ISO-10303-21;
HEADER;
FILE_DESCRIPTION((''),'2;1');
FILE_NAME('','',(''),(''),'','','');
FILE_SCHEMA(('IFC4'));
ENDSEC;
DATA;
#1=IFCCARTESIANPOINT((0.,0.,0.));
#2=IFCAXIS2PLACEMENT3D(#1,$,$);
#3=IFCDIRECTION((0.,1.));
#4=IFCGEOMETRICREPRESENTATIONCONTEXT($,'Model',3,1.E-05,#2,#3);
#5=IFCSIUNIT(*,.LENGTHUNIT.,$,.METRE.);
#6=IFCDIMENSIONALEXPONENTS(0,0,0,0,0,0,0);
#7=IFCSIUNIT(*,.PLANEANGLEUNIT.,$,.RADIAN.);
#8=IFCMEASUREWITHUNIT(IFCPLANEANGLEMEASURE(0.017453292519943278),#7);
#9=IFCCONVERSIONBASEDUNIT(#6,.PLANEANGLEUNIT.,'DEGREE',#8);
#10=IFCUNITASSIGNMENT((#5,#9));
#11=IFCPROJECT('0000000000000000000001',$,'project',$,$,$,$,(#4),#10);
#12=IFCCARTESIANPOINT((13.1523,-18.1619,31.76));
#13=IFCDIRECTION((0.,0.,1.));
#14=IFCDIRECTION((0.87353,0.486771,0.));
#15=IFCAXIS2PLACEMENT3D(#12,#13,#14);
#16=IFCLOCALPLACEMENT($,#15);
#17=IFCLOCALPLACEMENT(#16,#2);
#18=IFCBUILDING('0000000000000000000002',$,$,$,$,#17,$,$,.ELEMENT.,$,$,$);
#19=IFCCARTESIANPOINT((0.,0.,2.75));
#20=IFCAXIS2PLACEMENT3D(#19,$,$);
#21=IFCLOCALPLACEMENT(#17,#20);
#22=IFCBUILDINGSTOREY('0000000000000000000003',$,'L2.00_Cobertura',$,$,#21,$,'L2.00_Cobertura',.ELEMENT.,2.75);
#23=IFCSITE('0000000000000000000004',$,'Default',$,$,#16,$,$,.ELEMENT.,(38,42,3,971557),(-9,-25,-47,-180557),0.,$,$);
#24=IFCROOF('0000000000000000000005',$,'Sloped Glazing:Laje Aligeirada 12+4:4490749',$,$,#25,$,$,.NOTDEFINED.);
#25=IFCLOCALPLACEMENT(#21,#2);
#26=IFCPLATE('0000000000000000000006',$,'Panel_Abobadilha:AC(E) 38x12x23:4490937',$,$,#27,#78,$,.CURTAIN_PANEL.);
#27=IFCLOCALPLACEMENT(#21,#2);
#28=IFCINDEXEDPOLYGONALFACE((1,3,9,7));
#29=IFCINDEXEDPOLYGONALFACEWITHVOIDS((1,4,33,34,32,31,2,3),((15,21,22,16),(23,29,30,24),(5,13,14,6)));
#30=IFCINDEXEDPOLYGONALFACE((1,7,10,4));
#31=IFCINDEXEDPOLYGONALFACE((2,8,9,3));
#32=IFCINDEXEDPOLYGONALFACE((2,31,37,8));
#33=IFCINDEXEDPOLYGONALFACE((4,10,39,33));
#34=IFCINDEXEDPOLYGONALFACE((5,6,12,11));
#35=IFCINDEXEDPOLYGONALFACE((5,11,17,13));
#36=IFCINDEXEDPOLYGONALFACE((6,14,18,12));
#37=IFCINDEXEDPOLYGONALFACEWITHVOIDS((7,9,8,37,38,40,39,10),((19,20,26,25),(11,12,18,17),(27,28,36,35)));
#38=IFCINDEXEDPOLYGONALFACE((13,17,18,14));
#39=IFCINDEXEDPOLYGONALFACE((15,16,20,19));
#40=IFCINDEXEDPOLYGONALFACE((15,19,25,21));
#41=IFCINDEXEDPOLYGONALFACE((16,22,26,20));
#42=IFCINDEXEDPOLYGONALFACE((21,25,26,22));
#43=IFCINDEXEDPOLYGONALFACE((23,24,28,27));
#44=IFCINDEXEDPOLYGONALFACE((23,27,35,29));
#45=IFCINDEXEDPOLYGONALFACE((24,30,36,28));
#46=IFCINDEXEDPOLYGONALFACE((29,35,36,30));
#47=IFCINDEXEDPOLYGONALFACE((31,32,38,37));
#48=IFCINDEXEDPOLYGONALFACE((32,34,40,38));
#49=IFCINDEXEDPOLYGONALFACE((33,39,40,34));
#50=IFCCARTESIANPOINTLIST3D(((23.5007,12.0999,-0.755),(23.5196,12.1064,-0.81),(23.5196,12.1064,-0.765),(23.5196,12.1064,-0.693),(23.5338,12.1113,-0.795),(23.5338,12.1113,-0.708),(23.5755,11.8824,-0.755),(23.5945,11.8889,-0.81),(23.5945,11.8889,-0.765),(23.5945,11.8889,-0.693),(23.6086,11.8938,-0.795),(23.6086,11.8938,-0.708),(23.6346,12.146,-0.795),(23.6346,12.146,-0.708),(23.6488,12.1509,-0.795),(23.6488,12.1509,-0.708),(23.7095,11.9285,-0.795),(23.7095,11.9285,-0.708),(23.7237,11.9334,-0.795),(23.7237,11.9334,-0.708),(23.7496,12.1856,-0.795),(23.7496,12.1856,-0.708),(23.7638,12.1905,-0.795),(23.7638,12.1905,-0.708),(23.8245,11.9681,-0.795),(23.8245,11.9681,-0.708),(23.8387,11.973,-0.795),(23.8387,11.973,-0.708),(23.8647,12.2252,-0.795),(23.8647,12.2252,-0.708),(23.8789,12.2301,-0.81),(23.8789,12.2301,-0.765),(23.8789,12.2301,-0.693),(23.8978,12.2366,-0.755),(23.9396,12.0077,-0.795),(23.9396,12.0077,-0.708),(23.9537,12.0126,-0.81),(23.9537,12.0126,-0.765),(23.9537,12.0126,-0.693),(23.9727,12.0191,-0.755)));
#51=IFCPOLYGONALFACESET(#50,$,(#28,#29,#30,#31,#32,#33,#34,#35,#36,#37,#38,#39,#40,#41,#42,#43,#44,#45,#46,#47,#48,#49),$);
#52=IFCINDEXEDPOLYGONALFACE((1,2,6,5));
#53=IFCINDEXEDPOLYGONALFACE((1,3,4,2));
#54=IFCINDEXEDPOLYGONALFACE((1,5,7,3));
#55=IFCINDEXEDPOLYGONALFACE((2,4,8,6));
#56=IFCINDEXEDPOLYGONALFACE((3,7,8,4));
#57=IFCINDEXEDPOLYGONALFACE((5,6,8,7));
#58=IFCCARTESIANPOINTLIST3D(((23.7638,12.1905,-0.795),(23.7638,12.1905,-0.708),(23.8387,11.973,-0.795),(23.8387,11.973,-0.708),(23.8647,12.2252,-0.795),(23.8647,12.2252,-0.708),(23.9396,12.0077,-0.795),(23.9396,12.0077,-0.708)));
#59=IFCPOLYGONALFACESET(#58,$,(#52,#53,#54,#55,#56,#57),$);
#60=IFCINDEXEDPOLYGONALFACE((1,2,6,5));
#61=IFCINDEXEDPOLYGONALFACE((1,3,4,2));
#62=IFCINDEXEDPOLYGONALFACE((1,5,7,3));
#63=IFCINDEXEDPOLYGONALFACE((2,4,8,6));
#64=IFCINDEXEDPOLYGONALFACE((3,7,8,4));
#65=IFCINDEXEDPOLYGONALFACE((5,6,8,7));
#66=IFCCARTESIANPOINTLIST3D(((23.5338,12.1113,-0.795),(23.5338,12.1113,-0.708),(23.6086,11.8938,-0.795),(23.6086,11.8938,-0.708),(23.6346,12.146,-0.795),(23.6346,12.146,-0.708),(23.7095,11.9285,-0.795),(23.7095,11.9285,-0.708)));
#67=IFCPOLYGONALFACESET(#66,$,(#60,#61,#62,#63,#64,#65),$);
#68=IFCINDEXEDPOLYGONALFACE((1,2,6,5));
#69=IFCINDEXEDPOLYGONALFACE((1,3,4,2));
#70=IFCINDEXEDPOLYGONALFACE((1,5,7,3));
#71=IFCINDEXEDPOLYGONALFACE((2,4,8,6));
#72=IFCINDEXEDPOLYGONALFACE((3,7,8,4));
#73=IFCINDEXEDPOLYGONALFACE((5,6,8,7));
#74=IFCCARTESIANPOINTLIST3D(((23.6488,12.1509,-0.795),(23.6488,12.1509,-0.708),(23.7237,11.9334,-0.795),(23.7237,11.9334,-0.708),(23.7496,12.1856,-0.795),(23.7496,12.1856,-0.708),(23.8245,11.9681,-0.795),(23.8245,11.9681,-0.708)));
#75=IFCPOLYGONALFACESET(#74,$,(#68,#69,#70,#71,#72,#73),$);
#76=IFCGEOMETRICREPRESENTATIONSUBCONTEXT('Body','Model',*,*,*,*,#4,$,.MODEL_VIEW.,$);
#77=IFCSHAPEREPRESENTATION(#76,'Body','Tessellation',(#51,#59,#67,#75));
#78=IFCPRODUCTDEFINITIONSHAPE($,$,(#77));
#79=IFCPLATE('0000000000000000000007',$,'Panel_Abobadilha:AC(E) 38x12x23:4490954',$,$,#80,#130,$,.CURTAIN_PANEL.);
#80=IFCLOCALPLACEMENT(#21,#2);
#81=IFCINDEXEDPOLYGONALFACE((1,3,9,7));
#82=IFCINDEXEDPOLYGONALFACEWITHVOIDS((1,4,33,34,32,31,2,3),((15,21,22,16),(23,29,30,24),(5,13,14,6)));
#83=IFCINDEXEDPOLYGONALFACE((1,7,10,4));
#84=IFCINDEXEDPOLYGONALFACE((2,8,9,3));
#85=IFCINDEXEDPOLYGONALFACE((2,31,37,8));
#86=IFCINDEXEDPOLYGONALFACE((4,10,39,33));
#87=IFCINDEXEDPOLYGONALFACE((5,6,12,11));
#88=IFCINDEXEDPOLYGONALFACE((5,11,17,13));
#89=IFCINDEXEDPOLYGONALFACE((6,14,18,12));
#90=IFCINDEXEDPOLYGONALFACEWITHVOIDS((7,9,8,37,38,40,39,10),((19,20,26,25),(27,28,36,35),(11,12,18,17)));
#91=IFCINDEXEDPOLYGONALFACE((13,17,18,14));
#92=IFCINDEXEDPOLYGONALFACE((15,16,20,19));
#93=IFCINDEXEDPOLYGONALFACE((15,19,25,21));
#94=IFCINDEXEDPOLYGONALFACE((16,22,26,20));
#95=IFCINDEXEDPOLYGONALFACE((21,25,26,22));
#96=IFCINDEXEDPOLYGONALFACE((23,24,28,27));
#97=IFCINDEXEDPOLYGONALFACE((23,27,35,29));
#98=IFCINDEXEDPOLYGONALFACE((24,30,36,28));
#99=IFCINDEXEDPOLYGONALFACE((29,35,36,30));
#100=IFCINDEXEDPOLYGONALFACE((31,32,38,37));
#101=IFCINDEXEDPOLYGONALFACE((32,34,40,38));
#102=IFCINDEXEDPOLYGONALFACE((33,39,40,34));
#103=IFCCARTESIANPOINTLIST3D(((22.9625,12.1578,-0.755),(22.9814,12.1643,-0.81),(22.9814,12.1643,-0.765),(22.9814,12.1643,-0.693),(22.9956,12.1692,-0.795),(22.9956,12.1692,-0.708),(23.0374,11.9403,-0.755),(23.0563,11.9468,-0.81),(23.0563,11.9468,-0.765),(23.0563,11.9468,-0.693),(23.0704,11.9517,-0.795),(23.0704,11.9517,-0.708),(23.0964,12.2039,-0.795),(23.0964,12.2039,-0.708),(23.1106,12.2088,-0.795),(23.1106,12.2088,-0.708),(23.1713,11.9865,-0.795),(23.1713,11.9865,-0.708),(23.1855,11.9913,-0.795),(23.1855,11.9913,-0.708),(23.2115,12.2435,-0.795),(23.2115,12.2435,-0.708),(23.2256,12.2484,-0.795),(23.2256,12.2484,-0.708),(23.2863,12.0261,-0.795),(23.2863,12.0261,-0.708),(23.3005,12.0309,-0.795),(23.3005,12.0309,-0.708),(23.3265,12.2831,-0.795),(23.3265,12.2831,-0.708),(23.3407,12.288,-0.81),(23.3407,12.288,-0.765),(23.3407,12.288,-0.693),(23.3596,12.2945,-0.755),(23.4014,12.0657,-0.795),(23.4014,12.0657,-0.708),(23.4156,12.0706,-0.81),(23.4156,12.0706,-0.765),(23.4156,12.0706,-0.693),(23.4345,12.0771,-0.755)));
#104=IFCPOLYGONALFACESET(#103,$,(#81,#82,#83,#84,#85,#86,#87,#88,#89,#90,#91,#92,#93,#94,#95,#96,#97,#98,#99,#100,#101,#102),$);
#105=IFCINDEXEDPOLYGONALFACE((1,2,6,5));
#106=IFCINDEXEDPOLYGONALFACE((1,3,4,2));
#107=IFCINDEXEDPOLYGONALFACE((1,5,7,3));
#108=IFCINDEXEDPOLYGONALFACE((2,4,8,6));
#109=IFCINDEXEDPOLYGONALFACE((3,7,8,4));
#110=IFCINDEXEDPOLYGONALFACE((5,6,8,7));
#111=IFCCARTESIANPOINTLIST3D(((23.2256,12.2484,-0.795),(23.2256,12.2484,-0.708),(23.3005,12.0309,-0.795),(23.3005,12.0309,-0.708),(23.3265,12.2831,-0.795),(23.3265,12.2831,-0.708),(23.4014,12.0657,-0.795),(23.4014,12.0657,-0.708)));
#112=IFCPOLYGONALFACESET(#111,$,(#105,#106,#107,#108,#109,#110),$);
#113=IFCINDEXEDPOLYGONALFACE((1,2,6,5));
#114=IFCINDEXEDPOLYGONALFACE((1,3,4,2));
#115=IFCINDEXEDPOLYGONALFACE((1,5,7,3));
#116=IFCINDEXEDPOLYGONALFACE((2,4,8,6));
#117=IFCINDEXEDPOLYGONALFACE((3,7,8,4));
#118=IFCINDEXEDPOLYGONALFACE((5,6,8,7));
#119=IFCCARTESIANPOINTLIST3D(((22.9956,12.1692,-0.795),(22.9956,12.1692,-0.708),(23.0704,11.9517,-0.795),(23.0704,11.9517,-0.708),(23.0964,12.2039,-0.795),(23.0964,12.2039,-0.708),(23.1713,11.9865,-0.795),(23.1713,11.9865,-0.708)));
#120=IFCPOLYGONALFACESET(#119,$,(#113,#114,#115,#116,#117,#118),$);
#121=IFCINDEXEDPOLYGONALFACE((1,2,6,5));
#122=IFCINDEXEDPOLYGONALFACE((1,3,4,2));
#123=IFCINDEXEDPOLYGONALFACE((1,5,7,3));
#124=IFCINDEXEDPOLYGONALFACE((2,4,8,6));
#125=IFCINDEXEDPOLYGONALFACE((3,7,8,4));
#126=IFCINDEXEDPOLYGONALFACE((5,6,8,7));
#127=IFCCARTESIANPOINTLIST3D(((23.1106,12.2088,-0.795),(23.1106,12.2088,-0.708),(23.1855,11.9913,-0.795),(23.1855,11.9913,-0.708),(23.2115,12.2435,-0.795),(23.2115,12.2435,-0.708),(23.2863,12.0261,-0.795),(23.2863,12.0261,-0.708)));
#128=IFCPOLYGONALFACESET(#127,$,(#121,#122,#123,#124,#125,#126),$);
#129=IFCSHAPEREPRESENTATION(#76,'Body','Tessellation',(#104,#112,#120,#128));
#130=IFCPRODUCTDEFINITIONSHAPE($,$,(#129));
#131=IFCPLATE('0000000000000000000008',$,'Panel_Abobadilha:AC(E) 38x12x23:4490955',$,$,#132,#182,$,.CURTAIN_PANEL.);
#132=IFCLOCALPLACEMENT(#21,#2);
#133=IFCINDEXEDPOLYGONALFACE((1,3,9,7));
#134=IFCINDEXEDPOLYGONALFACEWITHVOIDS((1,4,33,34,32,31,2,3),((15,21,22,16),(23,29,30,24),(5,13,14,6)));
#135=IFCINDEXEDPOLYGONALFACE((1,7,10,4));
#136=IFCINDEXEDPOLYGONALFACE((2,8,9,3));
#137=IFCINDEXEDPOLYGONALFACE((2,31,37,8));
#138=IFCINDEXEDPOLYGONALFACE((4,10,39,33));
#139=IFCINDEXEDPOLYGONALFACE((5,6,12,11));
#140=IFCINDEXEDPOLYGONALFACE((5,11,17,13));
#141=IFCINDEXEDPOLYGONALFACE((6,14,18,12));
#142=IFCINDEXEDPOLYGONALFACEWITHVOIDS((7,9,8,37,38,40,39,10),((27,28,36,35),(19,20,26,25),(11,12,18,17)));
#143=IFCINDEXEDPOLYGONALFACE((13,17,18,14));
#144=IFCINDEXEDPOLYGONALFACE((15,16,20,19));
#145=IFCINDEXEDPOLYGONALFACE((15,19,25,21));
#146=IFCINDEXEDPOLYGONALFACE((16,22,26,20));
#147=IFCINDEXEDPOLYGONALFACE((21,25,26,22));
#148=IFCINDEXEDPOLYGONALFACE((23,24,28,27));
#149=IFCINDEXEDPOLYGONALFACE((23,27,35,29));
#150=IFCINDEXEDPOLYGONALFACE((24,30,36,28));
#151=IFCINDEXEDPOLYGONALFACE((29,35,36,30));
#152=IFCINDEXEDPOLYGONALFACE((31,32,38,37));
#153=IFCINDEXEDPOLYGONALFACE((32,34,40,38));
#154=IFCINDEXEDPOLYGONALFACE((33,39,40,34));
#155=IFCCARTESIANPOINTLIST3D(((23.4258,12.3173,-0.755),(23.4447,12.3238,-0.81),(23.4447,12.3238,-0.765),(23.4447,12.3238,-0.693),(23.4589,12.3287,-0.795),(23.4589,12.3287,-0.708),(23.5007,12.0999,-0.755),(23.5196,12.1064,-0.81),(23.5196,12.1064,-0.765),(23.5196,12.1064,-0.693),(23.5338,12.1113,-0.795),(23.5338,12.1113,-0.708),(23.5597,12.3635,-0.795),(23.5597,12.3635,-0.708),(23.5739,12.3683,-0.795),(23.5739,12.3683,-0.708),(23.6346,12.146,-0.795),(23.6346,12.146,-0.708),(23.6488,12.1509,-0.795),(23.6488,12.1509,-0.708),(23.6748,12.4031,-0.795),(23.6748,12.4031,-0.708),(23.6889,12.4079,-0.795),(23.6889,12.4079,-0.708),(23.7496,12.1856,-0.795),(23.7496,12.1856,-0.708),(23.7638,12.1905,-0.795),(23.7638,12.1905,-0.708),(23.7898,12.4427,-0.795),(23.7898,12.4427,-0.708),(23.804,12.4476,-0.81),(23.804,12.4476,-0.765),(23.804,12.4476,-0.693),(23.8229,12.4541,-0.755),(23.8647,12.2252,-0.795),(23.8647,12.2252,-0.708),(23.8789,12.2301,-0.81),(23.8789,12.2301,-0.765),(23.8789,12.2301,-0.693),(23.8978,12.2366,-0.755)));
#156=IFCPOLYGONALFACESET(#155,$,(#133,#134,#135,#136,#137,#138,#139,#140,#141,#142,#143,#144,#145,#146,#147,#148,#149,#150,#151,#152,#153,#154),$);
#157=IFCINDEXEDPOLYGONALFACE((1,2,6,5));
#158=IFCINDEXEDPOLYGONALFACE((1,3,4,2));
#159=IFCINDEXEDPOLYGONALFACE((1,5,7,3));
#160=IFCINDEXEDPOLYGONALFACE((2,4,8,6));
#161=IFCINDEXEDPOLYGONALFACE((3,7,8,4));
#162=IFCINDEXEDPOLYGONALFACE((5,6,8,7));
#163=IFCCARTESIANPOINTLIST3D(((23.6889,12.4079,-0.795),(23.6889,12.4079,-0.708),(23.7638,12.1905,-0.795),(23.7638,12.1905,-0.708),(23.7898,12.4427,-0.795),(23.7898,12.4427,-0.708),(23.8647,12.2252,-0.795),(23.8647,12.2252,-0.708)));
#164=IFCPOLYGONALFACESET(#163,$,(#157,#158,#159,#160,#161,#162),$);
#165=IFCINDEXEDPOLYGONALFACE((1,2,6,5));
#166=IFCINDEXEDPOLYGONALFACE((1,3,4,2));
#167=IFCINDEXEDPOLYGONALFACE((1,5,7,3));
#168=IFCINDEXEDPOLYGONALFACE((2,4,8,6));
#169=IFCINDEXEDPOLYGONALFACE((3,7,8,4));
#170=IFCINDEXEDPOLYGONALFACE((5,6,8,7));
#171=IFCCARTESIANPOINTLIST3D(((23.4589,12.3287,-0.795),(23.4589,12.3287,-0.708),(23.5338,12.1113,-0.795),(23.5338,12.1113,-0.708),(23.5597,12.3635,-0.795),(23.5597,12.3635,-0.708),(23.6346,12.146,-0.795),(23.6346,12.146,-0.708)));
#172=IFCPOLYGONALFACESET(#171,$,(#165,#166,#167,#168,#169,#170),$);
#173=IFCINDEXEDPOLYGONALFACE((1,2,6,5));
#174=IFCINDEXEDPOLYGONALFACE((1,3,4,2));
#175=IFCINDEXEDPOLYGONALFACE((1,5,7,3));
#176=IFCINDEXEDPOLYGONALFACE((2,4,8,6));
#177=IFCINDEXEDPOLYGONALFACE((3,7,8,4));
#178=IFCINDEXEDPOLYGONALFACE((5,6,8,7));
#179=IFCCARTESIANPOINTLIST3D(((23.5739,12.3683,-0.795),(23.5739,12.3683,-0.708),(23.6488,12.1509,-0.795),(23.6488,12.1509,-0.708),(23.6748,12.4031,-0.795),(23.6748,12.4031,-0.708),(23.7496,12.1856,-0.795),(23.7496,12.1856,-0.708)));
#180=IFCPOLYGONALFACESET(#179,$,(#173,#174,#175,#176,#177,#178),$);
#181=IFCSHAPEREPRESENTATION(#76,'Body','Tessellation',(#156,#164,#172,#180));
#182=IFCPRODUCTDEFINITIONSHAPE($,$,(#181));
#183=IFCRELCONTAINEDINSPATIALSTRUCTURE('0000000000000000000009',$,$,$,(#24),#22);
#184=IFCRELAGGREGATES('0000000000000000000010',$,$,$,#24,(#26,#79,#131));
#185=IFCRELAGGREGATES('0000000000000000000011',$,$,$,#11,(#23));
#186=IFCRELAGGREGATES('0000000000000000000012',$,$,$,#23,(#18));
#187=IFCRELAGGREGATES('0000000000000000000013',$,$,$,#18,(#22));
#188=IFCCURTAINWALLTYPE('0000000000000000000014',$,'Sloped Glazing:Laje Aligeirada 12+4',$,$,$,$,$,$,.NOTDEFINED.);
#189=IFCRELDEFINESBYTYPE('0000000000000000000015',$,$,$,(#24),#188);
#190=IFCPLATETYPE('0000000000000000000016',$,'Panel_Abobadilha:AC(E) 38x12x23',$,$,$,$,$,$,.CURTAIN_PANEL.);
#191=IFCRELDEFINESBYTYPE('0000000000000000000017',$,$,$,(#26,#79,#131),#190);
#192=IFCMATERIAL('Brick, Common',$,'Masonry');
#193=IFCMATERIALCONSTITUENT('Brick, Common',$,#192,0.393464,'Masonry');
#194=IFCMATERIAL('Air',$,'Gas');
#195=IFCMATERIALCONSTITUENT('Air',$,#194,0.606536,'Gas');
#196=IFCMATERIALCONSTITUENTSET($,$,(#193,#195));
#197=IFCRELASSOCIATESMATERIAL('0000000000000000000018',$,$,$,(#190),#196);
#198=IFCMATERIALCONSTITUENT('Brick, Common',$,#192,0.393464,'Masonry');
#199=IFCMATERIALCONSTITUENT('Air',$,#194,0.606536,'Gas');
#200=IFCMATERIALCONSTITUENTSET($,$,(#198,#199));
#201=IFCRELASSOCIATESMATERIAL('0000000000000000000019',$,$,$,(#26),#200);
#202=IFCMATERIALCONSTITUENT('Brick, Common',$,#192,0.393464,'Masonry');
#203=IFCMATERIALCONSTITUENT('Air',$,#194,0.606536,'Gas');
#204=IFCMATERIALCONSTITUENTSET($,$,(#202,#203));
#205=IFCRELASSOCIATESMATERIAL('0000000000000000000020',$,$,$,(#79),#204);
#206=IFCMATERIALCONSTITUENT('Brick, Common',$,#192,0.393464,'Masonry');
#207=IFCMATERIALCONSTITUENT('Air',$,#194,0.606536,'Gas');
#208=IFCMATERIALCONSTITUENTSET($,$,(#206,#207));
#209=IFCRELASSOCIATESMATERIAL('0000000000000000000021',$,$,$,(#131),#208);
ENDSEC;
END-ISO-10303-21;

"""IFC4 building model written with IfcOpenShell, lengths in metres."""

from ifc_helpers import new_model, entity, si_unit, converted_unit, direction, frame, origin, place, context, subcontext, project, spatial, indexed_curve, outline, extrude, source, transform, mapped, material, constituent, constituent_set, type_object, type_shapes, element, aggregate, save


model = new_model("IFC4")

# Units and contexts
model_context = context("Model", 3, precision=1e-05, world=origin(), true_north=direction((0.0, 1.0)))
body_context = subcontext(model_context, "Body", "Model", "MODEL_VIEW")
ifc_project = project(units=[si_unit("LENGTHUNIT", "METRE"), converted_unit("PLANEANGLEUNIT", "DEGREE", entity("IfcPlaneAngleMeasure", 0.017453292519943278), si_unit("PLANEANGLEUNIT", "RADIAN"), dimensions=[0, 0, 0, 0, 0, 0, 0])], contexts=[model_context])

# Site, building, storey
site_placement = place(None, frame((13.1523, -18.1619, 31.76), z_axis=(0.0, 0.0, 1.0), x_axis=(0.87353, 0.486771, 0.0)))
site = spatial("IfcSite", under=ifc_project, at=site_placement, Name="Default", CompositionType="ELEMENT", RefLatitude=(38, 42, 3, 971557), RefLongitude=(-9, -25, -47, -180557), RefElevation=0.0)
building_placement = place(site_placement, origin())
building = spatial("IfcBuilding", under=site, at=building_placement, CompositionType="ELEMENT")
storey_placement = place(building_placement, frame((0.0, 0.0, 2.75)))
storey = spatial("IfcBuildingStorey", under=building, at=storey_placement, Name="L2.00_Cobertura", LongName="L2.00_Cobertura", CompositionType="ELEMENT", Elevation=2.75)

# Roof, plates
curtain_wall_type = type_object("IfcCurtainWallType", Name="Sloped Glazing:Laje Aligeirada 12+4", PredefinedType="NOTDEFINED")
roof_placement = place(storey_placement, frame((0.0, 0.0, -2.75)))
roof = element("IfcRoof", 1, at=roof_placement, inside=storey, type_object=curtain_wall_type, Name="Sloped Glazing:Laje Aligeirada 12+4:4490749", PredefinedType="NOTDEFINED")
ifc_material_1 = material(Name="Brick, Common", Category="Masonry")
ifc_material_2 = material(Name="Air", Category="Gas")
ifc_constituent_1 = constituent(ifc_material_1, Name="Brick, Common", Category="Masonry", fraction=0.393464)
ifc_constituent_2 = constituent(ifc_material_2, Name="Air", Category="Gas", fraction=0.606536)
ifc_constituent_set_1 = constituent_set(constituents=[ifc_constituent_1, ifc_constituent_2])
plate_type_1 = type_object("IfcPlateType", Name="Panel_Abobadilha:AC(E) 38x12x23", PredefinedType="CURTAIN_PANEL", material=ifc_constituent_set_1)
shared_shape_1 = source(origin(), body_context, "Body", "SweptSolid", [
    extrude(outline(indexed_curve([(-0.19, -0.0543), (0.19, -0.0543), (0.19, -0.0093), (0.21, 0.0007), (0.19, 0.0628), (-0.19, 0.0628), (-0.21, 0.0007), (-0.19, -0.0093), (-0.19, -0.0543)], self_intersect=False), holes=[indexed_curve([(-0.0683, 0.0477), (-0.0683, -0.0393), (-0.175, -0.0393), (-0.175, 0.0477), (-0.0683, 0.0477)], self_intersect=False), indexed_curve([(0.0533, 0.0477), (0.0533, -0.0393), (-0.0533, -0.0393), (-0.0533, 0.0477), (0.0533, 0.0477)], self_intersect=False), indexed_curve([(0.175, 0.0477), (0.175, -0.0393), (0.0683, -0.0393), (0.0683, 0.0477), (0.175, 0.0477)], self_intersect=False)]), frame((0.0, 0.0543, 0.0)), (0.0, 0.0, 1.0), 0.23),
    extrude(outline(indexed_curve([(-0.0533, -0.0435), (0.0533, -0.0435), (0.0533, 0.0435), (-0.0533, 0.0435), (-0.0533, -0.0435)], self_intersect=False)), frame((0.1217, 0.0585, 0.0), z_axis=(0.0, 0.0, 1.0), x_axis=(-1.0, 0.0, 0.0)), (0.0, 0.0, 1.0), 0.23),
    extrude(outline(indexed_curve([(-0.0533, -0.0435), (0.0533, -0.0435), (0.0533, 0.0435), (-0.0533, 0.0435), (-0.0533, -0.0435)], self_intersect=False)), frame((-0.1217, 0.0585, 0.0), z_axis=(0.0, 0.0, 1.0), x_axis=(-1.0, 0.0, 0.0)), (0.0, 0.0, 1.0), 0.23),
    extrude(outline(indexed_curve([(-0.0533, -0.0435), (0.0533, -0.0435), (0.0533, 0.0435), (-0.0533, 0.0435), (-0.0533, -0.0435)], self_intersect=False)), frame((0.0, 0.0585, 0.0), z_axis=(0.0, 0.0, 1.0), x_axis=(-1.0, 0.0, 0.0)), (0.0, 0.0, 1.0), 0.23),
])
type_shapes(plate_type_1, [shared_shape_1])
ifc_constituent_3 = constituent(ifc_material_1, Name="Brick, Common", Category="Masonry", fraction=0.393464)
ifc_constituent_4 = constituent(ifc_material_2, Name="Air", Category="Gas", fraction=0.606536)
ifc_constituent_set_2 = constituent_set(constituents=[ifc_constituent_3, ifc_constituent_4])
plate_1_placement = place(roof_placement, frame((23.6992, 12.1682, 1.94), z_axis=(0.325568, -0.945519, 0.0), x_axis=(0.945519, 0.325568, 0.0)))
plate_1 = element("IfcPlate", 2, at=plate_1_placement, type_object=plate_type_1, material=ifc_constituent_set_2, Name="Panel_Abobadilha:AC(E) 38x12x23:4490937", PredefinedType="CURTAIN_PANEL", context=body_context, shape_type="MappedRepresentation", body=[
    mapped(shared_shape_1, transform((0.0, 0.0, 0.0), scale=1.0)),
])
ifc_constituent_5 = constituent(ifc_material_1, Name="Brick, Common", Category="Masonry", fraction=0.393464)
ifc_constituent_6 = constituent(ifc_material_2, Name="Air", Category="Gas", fraction=0.606536)
ifc_constituent_set_3 = constituent_set(constituents=[ifc_constituent_5, ifc_constituent_6])
plate_2_placement = place(roof_placement, frame((23.161, 12.2262, 1.94), z_axis=(0.325568, -0.945519, 0.0), x_axis=(0.945519, 0.325568, 0.0)))
plate_2 = element("IfcPlate", 3, at=plate_2_placement, type_object=plate_type_1, material=ifc_constituent_set_3, Name="Panel_Abobadilha:AC(E) 38x12x23:4490954", PredefinedType="CURTAIN_PANEL", context=body_context, shape_type="MappedRepresentation", body=[
    mapped(shared_shape_1, transform((0.0, 0.0, 0.0), scale=1.0)),
])
ifc_constituent_7 = constituent(ifc_material_1, Name="Brick, Common", Category="Masonry", fraction=0.393464)
ifc_constituent_8 = constituent(ifc_material_2, Name="Air", Category="Gas", fraction=0.606536)
ifc_constituent_set_4 = constituent_set(constituents=[ifc_constituent_7, ifc_constituent_8])
plate_3_placement = place(roof_placement, frame((23.6243, 12.3857, 1.94), z_axis=(0.325568, -0.945519, 0.0), x_axis=(0.945519, 0.325568, 0.0)))
plate_3 = element("IfcPlate", 4, at=plate_3_placement, type_object=plate_type_1, material=ifc_constituent_set_4, Name="Panel_Abobadilha:AC(E) 38x12x23:4490955", PredefinedType="CURTAIN_PANEL", context=body_context, shape_type="MappedRepresentation", body=[
    mapped(shared_shape_1, transform((0.0, 0.0, 0.0), scale=1.0)),
])
aggregate(roof, [plate_1, plate_2, plate_3])

save(model, "model.ifc")
